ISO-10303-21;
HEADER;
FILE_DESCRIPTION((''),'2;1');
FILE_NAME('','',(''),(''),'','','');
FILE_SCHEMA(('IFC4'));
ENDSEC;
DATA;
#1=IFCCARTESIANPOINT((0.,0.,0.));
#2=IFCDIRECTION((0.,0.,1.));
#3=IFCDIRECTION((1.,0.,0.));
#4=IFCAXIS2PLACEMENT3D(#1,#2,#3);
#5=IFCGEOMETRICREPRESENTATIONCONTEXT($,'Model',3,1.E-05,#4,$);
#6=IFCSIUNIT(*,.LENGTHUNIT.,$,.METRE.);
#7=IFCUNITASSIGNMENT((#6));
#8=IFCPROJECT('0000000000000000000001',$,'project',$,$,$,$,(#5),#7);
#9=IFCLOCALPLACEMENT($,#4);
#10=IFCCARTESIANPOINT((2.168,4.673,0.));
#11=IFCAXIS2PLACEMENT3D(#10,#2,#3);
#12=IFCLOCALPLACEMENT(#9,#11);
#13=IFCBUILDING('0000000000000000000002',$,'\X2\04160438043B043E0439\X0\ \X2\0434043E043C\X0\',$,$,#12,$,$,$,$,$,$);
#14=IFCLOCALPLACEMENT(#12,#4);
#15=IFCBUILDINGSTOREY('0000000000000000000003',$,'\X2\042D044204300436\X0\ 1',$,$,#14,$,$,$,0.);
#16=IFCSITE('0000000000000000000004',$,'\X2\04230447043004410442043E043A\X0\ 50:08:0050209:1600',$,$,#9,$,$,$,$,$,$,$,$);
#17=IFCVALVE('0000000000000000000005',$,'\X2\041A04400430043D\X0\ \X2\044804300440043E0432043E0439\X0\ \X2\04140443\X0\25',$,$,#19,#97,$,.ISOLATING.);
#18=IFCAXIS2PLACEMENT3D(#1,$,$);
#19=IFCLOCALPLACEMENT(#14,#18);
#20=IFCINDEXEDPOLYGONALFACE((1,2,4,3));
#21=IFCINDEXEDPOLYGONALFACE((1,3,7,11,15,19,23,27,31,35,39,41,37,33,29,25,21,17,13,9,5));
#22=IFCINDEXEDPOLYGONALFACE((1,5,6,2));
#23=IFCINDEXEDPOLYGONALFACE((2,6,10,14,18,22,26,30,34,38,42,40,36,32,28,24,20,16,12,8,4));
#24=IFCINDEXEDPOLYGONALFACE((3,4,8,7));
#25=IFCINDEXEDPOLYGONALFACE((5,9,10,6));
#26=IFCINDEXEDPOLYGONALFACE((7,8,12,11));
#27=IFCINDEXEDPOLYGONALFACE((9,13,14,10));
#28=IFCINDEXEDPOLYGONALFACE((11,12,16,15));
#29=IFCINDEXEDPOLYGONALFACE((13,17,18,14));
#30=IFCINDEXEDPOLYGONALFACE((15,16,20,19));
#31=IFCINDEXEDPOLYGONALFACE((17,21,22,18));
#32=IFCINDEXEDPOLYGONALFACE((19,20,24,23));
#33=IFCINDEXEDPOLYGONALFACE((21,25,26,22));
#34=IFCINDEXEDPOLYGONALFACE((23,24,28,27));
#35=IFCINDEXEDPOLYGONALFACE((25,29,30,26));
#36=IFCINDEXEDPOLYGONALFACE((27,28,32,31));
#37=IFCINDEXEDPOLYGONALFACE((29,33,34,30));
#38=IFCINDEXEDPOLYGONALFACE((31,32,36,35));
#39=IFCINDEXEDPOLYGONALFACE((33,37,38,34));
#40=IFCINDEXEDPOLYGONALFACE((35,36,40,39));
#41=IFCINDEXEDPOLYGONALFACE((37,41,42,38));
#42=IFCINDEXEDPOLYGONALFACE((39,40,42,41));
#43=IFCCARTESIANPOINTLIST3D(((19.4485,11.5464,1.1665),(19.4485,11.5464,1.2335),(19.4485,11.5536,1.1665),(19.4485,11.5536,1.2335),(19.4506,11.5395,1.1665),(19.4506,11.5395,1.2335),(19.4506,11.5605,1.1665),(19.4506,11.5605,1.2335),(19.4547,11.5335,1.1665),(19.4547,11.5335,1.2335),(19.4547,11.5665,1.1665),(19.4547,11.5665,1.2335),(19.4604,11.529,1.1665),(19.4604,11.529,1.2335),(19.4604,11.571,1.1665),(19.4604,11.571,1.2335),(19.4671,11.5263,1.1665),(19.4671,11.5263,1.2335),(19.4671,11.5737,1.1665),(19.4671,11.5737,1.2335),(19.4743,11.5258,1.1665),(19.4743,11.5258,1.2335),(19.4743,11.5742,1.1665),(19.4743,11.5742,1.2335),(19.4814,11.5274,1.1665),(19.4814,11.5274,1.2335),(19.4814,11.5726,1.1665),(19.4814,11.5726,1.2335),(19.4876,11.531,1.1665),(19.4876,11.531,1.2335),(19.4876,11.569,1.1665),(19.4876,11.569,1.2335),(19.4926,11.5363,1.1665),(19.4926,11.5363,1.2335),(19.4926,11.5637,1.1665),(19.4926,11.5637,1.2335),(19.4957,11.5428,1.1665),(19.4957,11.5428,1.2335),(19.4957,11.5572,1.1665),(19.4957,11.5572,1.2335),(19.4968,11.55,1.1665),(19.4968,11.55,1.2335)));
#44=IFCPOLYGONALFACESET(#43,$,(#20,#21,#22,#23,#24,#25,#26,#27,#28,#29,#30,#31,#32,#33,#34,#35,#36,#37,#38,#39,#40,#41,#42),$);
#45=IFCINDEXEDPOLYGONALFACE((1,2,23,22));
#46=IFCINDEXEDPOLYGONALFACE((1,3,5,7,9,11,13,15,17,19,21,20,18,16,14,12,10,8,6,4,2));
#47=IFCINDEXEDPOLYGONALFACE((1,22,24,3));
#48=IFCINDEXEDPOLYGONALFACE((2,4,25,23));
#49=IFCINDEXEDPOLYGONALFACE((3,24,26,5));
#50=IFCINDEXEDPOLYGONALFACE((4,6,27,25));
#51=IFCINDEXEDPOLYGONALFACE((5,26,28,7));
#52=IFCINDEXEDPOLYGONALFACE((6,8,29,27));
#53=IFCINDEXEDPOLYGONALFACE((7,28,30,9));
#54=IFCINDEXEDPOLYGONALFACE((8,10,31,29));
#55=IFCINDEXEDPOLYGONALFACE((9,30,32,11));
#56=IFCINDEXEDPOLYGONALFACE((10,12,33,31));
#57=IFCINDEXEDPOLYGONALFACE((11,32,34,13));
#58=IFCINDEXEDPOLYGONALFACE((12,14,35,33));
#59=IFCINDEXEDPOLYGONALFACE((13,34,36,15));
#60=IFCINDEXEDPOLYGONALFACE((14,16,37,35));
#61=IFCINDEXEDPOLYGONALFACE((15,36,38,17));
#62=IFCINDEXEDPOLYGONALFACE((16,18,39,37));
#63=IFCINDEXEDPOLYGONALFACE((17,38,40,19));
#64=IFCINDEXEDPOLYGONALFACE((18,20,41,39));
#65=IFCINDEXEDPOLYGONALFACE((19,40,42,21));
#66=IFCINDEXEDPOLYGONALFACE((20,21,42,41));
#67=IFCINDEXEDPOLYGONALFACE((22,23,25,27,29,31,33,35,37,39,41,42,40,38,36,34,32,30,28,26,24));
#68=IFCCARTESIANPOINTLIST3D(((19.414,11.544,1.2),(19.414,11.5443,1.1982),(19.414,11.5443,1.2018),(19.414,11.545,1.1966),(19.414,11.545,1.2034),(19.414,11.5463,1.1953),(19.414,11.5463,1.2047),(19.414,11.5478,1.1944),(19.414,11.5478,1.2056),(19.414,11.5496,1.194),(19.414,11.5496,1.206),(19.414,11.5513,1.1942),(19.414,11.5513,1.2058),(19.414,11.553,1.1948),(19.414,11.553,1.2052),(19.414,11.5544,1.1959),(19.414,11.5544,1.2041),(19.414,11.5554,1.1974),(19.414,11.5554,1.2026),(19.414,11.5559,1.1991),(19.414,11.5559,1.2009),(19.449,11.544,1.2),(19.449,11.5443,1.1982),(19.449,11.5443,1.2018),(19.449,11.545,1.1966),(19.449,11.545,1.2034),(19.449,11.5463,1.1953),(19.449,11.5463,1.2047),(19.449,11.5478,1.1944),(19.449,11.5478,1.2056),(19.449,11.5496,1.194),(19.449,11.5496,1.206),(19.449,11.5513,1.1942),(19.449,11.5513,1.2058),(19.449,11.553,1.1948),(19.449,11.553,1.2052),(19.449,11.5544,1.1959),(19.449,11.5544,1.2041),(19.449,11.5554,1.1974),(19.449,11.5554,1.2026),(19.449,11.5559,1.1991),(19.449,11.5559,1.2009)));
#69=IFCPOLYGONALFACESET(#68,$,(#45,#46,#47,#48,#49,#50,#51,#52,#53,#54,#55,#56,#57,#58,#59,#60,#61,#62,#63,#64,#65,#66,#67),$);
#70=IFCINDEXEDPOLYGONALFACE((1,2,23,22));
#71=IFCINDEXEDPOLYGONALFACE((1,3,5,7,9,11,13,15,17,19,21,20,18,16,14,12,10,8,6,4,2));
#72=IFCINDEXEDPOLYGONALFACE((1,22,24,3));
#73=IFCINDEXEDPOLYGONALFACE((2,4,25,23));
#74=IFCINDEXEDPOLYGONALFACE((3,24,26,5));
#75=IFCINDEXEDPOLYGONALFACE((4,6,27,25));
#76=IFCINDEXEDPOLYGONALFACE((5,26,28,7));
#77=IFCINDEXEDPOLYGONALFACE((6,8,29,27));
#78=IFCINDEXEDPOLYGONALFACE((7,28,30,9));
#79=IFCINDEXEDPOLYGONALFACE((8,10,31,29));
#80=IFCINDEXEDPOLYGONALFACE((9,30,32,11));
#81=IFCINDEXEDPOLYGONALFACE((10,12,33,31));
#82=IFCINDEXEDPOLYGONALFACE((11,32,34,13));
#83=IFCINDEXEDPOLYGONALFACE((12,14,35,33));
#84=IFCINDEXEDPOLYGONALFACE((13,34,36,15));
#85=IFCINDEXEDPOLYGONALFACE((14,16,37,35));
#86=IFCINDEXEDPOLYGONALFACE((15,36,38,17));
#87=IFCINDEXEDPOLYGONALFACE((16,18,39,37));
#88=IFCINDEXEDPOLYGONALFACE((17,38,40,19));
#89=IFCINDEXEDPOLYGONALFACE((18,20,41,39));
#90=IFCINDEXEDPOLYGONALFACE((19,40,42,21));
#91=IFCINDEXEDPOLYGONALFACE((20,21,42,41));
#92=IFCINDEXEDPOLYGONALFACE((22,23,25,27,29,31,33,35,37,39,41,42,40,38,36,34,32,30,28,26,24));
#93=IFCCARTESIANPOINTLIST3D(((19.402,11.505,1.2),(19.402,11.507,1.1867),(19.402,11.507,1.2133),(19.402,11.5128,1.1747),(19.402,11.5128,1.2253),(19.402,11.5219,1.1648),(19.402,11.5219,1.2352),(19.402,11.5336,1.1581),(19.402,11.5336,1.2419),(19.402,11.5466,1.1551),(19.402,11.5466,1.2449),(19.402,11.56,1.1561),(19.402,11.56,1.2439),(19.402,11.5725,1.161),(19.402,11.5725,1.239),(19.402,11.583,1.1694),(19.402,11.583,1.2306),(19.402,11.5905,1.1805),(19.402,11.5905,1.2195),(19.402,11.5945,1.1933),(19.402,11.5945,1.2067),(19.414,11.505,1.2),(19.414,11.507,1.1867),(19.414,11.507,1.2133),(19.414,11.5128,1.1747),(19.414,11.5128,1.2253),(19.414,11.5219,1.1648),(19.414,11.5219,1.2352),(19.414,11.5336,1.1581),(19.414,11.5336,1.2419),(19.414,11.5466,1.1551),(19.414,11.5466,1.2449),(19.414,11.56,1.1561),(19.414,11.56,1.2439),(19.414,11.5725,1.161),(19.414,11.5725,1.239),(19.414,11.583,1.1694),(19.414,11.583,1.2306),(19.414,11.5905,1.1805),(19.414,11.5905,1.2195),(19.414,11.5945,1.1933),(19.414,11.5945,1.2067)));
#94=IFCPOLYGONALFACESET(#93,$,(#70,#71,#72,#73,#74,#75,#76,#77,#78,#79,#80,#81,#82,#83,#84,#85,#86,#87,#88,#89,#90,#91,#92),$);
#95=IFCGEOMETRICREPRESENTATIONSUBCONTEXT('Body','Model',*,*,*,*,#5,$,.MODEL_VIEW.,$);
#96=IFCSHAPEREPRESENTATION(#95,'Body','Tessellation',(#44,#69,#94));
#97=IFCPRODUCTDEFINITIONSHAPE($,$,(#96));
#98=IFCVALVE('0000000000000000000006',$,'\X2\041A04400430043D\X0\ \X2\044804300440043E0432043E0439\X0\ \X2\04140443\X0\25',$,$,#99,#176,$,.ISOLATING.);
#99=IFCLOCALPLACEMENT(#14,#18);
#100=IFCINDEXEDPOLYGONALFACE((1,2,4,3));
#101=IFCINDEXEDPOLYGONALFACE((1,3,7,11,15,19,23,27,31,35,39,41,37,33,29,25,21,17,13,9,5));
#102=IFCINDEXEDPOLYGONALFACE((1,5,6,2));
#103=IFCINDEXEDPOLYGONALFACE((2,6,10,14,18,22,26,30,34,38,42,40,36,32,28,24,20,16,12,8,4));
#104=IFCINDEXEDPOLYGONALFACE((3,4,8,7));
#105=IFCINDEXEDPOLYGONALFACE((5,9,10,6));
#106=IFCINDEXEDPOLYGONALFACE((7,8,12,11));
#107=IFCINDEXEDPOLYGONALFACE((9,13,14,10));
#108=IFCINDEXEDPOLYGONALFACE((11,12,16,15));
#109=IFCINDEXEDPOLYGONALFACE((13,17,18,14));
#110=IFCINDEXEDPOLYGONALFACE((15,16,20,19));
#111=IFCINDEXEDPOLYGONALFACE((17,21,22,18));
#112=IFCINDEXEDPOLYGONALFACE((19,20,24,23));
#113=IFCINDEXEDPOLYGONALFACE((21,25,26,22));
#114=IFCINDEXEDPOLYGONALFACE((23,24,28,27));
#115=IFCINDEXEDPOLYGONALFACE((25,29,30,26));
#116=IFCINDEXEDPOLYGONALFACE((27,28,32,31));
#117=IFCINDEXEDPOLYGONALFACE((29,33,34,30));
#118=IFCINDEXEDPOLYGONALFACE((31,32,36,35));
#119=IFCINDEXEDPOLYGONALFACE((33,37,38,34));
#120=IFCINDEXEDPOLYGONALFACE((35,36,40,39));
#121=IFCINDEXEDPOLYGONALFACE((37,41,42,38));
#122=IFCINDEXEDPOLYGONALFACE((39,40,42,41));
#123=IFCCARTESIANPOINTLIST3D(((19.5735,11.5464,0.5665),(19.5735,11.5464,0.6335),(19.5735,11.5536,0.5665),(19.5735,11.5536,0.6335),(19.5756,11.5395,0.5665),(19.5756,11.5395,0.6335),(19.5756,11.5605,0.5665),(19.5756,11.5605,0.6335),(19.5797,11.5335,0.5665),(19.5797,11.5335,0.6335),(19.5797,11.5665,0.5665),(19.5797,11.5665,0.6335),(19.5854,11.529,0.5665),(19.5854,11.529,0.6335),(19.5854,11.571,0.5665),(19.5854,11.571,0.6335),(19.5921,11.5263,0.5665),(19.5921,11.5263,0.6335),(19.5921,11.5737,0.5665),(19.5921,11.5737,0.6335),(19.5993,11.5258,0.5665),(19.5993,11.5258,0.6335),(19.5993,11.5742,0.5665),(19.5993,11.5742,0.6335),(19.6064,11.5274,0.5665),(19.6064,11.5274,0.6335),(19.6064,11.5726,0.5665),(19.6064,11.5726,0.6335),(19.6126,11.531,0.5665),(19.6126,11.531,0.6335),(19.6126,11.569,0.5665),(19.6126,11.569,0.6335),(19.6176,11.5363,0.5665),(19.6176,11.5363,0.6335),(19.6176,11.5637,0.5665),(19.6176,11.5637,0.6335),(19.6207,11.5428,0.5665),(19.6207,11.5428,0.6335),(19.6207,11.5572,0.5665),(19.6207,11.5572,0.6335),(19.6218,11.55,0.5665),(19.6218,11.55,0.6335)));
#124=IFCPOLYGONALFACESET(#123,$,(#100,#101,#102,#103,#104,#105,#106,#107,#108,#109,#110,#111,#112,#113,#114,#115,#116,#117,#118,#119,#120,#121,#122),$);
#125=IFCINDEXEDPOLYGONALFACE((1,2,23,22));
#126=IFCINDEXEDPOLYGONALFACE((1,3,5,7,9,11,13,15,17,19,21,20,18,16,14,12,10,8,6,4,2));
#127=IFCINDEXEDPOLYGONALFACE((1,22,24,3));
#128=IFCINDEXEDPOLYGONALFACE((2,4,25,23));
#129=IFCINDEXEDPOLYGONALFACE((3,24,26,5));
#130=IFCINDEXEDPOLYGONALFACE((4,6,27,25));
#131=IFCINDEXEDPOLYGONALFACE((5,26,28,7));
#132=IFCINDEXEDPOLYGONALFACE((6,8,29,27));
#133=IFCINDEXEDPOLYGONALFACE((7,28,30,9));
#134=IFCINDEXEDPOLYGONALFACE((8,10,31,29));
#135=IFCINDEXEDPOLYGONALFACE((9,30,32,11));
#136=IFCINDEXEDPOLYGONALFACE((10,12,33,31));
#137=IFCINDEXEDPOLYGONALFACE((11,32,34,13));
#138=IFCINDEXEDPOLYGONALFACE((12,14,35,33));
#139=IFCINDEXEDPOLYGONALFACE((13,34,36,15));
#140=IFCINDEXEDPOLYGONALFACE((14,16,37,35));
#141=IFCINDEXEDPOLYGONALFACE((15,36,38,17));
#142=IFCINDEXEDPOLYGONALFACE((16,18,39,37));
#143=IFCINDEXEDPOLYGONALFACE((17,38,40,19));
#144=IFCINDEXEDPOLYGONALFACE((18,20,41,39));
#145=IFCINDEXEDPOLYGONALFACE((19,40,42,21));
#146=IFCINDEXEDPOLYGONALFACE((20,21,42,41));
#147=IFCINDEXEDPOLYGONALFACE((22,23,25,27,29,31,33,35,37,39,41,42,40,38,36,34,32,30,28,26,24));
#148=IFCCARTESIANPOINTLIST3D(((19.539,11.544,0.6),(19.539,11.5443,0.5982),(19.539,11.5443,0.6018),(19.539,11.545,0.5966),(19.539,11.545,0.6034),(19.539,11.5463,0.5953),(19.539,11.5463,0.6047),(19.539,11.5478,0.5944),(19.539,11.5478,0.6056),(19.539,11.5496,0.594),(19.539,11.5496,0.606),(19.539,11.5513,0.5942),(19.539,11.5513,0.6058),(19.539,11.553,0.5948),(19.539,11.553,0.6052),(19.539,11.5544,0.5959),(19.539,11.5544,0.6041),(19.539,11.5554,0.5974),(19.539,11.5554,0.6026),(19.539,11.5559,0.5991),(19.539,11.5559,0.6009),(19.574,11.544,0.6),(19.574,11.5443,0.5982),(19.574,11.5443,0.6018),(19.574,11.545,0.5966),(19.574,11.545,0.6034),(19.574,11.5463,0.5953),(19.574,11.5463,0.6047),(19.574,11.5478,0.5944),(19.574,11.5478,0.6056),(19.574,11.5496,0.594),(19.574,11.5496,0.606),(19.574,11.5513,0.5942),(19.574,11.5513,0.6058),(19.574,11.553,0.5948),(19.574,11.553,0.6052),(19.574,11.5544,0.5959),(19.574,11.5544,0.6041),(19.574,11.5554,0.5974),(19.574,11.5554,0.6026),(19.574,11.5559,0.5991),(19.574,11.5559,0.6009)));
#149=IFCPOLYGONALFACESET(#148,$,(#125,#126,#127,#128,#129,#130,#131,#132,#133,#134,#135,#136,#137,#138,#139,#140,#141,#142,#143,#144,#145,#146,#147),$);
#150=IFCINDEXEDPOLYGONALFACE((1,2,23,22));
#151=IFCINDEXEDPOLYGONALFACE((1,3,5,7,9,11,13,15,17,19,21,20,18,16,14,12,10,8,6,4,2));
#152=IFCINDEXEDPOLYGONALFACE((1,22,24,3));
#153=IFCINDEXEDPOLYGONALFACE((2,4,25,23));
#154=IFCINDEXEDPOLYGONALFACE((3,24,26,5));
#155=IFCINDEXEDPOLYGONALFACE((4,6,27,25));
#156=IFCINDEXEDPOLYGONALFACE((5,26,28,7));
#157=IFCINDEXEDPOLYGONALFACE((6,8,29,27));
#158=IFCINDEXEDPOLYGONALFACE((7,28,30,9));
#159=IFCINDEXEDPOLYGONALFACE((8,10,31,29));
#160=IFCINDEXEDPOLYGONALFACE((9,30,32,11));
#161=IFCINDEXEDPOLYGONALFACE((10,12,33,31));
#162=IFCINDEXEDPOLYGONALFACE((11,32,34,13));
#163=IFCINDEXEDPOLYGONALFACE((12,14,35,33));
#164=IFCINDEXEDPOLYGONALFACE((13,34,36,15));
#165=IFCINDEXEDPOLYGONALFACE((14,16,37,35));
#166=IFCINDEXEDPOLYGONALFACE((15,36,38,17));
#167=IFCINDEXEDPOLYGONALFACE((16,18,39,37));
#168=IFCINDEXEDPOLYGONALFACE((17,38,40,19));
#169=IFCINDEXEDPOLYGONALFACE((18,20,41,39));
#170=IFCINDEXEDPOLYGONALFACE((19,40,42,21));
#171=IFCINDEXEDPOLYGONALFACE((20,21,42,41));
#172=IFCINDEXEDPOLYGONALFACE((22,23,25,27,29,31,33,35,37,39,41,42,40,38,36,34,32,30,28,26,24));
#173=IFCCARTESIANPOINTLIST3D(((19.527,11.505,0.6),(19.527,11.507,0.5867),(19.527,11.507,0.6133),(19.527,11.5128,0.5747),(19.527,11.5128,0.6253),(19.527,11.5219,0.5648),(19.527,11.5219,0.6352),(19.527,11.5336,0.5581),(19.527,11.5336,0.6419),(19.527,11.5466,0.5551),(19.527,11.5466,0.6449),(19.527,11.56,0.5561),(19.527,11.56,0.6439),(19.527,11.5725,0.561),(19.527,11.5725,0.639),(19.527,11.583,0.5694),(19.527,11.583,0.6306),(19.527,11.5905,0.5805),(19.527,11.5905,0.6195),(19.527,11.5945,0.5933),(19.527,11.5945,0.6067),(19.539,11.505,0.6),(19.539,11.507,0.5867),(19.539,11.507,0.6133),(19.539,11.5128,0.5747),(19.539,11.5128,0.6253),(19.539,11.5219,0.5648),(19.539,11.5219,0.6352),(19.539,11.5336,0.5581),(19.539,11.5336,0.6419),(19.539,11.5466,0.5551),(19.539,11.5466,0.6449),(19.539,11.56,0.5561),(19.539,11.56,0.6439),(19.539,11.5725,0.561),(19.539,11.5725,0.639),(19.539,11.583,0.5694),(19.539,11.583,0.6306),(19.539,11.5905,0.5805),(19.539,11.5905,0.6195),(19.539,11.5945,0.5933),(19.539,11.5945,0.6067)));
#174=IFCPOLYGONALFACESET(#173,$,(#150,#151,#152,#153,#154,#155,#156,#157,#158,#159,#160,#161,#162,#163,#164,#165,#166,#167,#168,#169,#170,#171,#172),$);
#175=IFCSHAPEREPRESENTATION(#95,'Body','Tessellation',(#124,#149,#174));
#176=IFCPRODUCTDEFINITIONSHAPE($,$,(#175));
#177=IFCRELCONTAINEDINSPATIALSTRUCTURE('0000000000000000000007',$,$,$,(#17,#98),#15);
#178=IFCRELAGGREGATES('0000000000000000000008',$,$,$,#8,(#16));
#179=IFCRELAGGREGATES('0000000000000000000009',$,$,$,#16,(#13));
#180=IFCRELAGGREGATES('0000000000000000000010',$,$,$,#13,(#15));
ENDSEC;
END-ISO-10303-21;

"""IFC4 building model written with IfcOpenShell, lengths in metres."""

from ifc_helpers import new_model, si_unit, frame, origin_with_axes, origin_2d, place, context, subcontext, project, spatial, circle, extrude, element, save


model = new_model("IFC4")

# Units and contexts
model_context = context("Model", 3, precision=1e-05, world=origin_with_axes())
body_context = subcontext(model_context, "Body", "Model", "MODEL_VIEW")
ifc_project = project(units=[si_unit("LENGTHUNIT", "METRE")], contexts=[model_context])

# Site, building, storey
site_placement = place(None, origin_with_axes())
site = spatial("IfcSite", under=ifc_project, at=site_placement, Name="Участок 50:08:0050209:1600")
building_placement = place(site_placement, frame((2.168, 4.673, 0.0), z_axis=(0.0, 0.0, 1.0), x_axis=(1.0, 0.0, 0.0)))
building = spatial("IfcBuilding", under=site, at=building_placement, Name="Жилой дом")
storey_placement = place(building_placement, origin_with_axes())
storey = spatial("IfcBuildingStorey", under=building, at=storey_placement, Name="Этаж 1", Elevation=0.0)

# Valves
valve_1_placement = place(storey_placement, origin_with_axes())
element("IfcValve", 1, at=valve_1_placement, inside=storey, Name="Кран шаровой Ду25", PredefinedType="ISOLATING", context=body_context, shape_type="SweptSolid", body=[
    extrude(circle(Radius=0.0243, at=origin_2d()), frame((19.4725, 11.55, 1.1665), z_axis=(0.0, 0.0, 1.0), x_axis=(1.0, 0.0, 0.0)), (0.0, 0.0, 1.0), 0.067),
    extrude(circle(Radius=0.006, at=origin_2d()), frame((19.449, 11.55, 1.2), z_axis=(-1.0, 0.0, 0.0), x_axis=(0.0, -1.0, 0.0)), (0.0, 0.0, 1.0), 0.035),
    extrude(circle(Radius=0.045, at=origin_2d()), frame((19.414, 11.55, 1.2), z_axis=(-1.0, 0.0, 0.0), x_axis=(0.0, -1.0, 0.0)), (0.0, 0.0, 1.0), 0.012),
])
valve_2_placement = place(storey_placement, origin_with_axes())
element("IfcValve", 2, at=valve_2_placement, inside=storey, Name="Кран шаровой Ду25", PredefinedType="ISOLATING", context=body_context, shape_type="SweptSolid", body=[
    extrude(circle(Radius=0.0243, at=origin_2d()), frame((19.5975, 11.55, 0.5665), z_axis=(0.0, 0.0, 1.0), x_axis=(1.0, 0.0, 0.0)), (0.0, 0.0, 1.0), 0.067),
    extrude(circle(Radius=0.006, at=origin_2d()), frame((19.574, 11.55, 0.6), z_axis=(-1.0, 0.0, 0.0), x_axis=(0.0, -1.0, 0.0)), (0.0, 0.0, 1.0), 0.035),
    extrude(circle(Radius=0.045, at=origin_2d()), frame((19.539, 11.55, 0.6), z_axis=(-1.0, 0.0, 0.0), x_axis=(0.0, -1.0, 0.0)), (0.0, 0.0, 1.0), 0.012),
])

save(model, "model.ifc")
